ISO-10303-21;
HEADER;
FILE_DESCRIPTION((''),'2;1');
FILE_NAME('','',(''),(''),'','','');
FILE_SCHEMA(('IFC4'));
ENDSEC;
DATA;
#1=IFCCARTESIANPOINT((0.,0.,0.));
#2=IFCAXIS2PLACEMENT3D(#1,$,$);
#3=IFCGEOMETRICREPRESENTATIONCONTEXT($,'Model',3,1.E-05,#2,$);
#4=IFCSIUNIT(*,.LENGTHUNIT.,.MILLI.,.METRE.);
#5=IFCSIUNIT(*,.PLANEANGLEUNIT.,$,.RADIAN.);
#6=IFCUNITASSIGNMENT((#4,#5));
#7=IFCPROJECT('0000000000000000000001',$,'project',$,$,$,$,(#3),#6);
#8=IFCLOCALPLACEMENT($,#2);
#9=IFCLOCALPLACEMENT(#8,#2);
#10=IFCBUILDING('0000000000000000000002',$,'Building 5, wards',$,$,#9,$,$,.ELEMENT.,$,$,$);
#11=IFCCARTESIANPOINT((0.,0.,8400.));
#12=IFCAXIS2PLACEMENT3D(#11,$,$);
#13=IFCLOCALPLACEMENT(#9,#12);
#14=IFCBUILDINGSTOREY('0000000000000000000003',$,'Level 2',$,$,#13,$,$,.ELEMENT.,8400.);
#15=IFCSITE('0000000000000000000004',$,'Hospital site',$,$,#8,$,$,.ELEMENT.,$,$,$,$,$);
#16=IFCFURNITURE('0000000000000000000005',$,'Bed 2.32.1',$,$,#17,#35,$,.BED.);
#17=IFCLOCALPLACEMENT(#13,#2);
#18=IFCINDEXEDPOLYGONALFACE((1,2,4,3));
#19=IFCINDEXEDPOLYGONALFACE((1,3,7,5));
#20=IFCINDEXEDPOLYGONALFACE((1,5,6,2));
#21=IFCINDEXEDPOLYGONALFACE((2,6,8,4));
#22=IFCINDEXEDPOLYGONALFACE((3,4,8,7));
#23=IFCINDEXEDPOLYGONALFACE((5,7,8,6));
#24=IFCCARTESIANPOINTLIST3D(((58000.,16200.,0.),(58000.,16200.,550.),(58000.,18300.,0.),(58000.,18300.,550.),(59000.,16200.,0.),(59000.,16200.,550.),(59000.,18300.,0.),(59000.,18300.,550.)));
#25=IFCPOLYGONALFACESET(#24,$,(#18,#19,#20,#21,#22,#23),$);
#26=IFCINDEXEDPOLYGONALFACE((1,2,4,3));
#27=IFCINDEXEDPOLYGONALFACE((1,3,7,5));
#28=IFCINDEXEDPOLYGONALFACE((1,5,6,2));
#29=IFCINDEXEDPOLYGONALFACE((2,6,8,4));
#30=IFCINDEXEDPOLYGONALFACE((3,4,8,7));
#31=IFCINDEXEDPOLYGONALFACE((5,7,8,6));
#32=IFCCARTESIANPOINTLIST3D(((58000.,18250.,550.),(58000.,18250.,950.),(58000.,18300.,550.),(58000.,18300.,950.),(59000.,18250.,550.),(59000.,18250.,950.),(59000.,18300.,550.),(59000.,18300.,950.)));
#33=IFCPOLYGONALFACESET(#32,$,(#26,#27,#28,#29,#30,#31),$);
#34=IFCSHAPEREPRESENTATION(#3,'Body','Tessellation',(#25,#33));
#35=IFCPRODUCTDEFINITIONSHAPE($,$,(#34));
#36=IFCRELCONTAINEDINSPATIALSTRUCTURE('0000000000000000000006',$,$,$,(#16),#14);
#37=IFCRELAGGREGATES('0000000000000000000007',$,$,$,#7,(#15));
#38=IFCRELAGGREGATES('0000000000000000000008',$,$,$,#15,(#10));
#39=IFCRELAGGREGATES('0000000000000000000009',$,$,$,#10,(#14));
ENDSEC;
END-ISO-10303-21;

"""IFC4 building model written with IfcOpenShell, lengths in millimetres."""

from ifc_helpers import new_model, si_unit, frame, frame_2d, origin, place, context, project, spatial, rectangle, extrude, element, save


model = new_model("IFC4")

# Units and contexts
model_context = context("Model", 3, precision=1e-05, world=origin())
ifc_project = project(units=[si_unit("LENGTHUNIT", "METRE", prefix="MILLI"), si_unit("PLANEANGLEUNIT", "RADIAN")], contexts=[model_context])

# Site, building, storey
site_placement = place(None, origin())
site = spatial("IfcSite", under=ifc_project, at=site_placement, Name="Hospital site", CompositionType="ELEMENT")
building_placement = place(site_placement, origin())
building = spatial("IfcBuilding", under=site, at=building_placement, Name="Building 5, wards", CompositionType="ELEMENT")
storey_placement = place(building_placement, frame((0.0, 0.0, 8400.0)))
storey = spatial("IfcBuildingStorey", under=building, at=storey_placement, Name="Level 2", CompositionType="ELEMENT", Elevation=8400.0)

# Furniture
furniture_placement = place(storey_placement, frame((58000.0, 16200.0, 0.0)))
element("IfcFurniture", 1, at=furniture_placement, inside=storey, Name="Bed 2.32.1", PredefinedType="BED", context=model_context, shape_type="SweptSolid", body=[
    extrude(rectangle(XDim=1000.0, YDim=2100.0, at=frame_2d((500.0, 1050.0))), origin(), (0.0, 0.0, 1.0), 550.0),
    extrude(rectangle(XDim=1000.0, YDim=50.0, at=frame_2d((500.0, 2075.0))), frame((0.0, 0.0, 550.0)), (0.0, 0.0, 1.0), 400.0),
])

save(model, "model.ifc")
